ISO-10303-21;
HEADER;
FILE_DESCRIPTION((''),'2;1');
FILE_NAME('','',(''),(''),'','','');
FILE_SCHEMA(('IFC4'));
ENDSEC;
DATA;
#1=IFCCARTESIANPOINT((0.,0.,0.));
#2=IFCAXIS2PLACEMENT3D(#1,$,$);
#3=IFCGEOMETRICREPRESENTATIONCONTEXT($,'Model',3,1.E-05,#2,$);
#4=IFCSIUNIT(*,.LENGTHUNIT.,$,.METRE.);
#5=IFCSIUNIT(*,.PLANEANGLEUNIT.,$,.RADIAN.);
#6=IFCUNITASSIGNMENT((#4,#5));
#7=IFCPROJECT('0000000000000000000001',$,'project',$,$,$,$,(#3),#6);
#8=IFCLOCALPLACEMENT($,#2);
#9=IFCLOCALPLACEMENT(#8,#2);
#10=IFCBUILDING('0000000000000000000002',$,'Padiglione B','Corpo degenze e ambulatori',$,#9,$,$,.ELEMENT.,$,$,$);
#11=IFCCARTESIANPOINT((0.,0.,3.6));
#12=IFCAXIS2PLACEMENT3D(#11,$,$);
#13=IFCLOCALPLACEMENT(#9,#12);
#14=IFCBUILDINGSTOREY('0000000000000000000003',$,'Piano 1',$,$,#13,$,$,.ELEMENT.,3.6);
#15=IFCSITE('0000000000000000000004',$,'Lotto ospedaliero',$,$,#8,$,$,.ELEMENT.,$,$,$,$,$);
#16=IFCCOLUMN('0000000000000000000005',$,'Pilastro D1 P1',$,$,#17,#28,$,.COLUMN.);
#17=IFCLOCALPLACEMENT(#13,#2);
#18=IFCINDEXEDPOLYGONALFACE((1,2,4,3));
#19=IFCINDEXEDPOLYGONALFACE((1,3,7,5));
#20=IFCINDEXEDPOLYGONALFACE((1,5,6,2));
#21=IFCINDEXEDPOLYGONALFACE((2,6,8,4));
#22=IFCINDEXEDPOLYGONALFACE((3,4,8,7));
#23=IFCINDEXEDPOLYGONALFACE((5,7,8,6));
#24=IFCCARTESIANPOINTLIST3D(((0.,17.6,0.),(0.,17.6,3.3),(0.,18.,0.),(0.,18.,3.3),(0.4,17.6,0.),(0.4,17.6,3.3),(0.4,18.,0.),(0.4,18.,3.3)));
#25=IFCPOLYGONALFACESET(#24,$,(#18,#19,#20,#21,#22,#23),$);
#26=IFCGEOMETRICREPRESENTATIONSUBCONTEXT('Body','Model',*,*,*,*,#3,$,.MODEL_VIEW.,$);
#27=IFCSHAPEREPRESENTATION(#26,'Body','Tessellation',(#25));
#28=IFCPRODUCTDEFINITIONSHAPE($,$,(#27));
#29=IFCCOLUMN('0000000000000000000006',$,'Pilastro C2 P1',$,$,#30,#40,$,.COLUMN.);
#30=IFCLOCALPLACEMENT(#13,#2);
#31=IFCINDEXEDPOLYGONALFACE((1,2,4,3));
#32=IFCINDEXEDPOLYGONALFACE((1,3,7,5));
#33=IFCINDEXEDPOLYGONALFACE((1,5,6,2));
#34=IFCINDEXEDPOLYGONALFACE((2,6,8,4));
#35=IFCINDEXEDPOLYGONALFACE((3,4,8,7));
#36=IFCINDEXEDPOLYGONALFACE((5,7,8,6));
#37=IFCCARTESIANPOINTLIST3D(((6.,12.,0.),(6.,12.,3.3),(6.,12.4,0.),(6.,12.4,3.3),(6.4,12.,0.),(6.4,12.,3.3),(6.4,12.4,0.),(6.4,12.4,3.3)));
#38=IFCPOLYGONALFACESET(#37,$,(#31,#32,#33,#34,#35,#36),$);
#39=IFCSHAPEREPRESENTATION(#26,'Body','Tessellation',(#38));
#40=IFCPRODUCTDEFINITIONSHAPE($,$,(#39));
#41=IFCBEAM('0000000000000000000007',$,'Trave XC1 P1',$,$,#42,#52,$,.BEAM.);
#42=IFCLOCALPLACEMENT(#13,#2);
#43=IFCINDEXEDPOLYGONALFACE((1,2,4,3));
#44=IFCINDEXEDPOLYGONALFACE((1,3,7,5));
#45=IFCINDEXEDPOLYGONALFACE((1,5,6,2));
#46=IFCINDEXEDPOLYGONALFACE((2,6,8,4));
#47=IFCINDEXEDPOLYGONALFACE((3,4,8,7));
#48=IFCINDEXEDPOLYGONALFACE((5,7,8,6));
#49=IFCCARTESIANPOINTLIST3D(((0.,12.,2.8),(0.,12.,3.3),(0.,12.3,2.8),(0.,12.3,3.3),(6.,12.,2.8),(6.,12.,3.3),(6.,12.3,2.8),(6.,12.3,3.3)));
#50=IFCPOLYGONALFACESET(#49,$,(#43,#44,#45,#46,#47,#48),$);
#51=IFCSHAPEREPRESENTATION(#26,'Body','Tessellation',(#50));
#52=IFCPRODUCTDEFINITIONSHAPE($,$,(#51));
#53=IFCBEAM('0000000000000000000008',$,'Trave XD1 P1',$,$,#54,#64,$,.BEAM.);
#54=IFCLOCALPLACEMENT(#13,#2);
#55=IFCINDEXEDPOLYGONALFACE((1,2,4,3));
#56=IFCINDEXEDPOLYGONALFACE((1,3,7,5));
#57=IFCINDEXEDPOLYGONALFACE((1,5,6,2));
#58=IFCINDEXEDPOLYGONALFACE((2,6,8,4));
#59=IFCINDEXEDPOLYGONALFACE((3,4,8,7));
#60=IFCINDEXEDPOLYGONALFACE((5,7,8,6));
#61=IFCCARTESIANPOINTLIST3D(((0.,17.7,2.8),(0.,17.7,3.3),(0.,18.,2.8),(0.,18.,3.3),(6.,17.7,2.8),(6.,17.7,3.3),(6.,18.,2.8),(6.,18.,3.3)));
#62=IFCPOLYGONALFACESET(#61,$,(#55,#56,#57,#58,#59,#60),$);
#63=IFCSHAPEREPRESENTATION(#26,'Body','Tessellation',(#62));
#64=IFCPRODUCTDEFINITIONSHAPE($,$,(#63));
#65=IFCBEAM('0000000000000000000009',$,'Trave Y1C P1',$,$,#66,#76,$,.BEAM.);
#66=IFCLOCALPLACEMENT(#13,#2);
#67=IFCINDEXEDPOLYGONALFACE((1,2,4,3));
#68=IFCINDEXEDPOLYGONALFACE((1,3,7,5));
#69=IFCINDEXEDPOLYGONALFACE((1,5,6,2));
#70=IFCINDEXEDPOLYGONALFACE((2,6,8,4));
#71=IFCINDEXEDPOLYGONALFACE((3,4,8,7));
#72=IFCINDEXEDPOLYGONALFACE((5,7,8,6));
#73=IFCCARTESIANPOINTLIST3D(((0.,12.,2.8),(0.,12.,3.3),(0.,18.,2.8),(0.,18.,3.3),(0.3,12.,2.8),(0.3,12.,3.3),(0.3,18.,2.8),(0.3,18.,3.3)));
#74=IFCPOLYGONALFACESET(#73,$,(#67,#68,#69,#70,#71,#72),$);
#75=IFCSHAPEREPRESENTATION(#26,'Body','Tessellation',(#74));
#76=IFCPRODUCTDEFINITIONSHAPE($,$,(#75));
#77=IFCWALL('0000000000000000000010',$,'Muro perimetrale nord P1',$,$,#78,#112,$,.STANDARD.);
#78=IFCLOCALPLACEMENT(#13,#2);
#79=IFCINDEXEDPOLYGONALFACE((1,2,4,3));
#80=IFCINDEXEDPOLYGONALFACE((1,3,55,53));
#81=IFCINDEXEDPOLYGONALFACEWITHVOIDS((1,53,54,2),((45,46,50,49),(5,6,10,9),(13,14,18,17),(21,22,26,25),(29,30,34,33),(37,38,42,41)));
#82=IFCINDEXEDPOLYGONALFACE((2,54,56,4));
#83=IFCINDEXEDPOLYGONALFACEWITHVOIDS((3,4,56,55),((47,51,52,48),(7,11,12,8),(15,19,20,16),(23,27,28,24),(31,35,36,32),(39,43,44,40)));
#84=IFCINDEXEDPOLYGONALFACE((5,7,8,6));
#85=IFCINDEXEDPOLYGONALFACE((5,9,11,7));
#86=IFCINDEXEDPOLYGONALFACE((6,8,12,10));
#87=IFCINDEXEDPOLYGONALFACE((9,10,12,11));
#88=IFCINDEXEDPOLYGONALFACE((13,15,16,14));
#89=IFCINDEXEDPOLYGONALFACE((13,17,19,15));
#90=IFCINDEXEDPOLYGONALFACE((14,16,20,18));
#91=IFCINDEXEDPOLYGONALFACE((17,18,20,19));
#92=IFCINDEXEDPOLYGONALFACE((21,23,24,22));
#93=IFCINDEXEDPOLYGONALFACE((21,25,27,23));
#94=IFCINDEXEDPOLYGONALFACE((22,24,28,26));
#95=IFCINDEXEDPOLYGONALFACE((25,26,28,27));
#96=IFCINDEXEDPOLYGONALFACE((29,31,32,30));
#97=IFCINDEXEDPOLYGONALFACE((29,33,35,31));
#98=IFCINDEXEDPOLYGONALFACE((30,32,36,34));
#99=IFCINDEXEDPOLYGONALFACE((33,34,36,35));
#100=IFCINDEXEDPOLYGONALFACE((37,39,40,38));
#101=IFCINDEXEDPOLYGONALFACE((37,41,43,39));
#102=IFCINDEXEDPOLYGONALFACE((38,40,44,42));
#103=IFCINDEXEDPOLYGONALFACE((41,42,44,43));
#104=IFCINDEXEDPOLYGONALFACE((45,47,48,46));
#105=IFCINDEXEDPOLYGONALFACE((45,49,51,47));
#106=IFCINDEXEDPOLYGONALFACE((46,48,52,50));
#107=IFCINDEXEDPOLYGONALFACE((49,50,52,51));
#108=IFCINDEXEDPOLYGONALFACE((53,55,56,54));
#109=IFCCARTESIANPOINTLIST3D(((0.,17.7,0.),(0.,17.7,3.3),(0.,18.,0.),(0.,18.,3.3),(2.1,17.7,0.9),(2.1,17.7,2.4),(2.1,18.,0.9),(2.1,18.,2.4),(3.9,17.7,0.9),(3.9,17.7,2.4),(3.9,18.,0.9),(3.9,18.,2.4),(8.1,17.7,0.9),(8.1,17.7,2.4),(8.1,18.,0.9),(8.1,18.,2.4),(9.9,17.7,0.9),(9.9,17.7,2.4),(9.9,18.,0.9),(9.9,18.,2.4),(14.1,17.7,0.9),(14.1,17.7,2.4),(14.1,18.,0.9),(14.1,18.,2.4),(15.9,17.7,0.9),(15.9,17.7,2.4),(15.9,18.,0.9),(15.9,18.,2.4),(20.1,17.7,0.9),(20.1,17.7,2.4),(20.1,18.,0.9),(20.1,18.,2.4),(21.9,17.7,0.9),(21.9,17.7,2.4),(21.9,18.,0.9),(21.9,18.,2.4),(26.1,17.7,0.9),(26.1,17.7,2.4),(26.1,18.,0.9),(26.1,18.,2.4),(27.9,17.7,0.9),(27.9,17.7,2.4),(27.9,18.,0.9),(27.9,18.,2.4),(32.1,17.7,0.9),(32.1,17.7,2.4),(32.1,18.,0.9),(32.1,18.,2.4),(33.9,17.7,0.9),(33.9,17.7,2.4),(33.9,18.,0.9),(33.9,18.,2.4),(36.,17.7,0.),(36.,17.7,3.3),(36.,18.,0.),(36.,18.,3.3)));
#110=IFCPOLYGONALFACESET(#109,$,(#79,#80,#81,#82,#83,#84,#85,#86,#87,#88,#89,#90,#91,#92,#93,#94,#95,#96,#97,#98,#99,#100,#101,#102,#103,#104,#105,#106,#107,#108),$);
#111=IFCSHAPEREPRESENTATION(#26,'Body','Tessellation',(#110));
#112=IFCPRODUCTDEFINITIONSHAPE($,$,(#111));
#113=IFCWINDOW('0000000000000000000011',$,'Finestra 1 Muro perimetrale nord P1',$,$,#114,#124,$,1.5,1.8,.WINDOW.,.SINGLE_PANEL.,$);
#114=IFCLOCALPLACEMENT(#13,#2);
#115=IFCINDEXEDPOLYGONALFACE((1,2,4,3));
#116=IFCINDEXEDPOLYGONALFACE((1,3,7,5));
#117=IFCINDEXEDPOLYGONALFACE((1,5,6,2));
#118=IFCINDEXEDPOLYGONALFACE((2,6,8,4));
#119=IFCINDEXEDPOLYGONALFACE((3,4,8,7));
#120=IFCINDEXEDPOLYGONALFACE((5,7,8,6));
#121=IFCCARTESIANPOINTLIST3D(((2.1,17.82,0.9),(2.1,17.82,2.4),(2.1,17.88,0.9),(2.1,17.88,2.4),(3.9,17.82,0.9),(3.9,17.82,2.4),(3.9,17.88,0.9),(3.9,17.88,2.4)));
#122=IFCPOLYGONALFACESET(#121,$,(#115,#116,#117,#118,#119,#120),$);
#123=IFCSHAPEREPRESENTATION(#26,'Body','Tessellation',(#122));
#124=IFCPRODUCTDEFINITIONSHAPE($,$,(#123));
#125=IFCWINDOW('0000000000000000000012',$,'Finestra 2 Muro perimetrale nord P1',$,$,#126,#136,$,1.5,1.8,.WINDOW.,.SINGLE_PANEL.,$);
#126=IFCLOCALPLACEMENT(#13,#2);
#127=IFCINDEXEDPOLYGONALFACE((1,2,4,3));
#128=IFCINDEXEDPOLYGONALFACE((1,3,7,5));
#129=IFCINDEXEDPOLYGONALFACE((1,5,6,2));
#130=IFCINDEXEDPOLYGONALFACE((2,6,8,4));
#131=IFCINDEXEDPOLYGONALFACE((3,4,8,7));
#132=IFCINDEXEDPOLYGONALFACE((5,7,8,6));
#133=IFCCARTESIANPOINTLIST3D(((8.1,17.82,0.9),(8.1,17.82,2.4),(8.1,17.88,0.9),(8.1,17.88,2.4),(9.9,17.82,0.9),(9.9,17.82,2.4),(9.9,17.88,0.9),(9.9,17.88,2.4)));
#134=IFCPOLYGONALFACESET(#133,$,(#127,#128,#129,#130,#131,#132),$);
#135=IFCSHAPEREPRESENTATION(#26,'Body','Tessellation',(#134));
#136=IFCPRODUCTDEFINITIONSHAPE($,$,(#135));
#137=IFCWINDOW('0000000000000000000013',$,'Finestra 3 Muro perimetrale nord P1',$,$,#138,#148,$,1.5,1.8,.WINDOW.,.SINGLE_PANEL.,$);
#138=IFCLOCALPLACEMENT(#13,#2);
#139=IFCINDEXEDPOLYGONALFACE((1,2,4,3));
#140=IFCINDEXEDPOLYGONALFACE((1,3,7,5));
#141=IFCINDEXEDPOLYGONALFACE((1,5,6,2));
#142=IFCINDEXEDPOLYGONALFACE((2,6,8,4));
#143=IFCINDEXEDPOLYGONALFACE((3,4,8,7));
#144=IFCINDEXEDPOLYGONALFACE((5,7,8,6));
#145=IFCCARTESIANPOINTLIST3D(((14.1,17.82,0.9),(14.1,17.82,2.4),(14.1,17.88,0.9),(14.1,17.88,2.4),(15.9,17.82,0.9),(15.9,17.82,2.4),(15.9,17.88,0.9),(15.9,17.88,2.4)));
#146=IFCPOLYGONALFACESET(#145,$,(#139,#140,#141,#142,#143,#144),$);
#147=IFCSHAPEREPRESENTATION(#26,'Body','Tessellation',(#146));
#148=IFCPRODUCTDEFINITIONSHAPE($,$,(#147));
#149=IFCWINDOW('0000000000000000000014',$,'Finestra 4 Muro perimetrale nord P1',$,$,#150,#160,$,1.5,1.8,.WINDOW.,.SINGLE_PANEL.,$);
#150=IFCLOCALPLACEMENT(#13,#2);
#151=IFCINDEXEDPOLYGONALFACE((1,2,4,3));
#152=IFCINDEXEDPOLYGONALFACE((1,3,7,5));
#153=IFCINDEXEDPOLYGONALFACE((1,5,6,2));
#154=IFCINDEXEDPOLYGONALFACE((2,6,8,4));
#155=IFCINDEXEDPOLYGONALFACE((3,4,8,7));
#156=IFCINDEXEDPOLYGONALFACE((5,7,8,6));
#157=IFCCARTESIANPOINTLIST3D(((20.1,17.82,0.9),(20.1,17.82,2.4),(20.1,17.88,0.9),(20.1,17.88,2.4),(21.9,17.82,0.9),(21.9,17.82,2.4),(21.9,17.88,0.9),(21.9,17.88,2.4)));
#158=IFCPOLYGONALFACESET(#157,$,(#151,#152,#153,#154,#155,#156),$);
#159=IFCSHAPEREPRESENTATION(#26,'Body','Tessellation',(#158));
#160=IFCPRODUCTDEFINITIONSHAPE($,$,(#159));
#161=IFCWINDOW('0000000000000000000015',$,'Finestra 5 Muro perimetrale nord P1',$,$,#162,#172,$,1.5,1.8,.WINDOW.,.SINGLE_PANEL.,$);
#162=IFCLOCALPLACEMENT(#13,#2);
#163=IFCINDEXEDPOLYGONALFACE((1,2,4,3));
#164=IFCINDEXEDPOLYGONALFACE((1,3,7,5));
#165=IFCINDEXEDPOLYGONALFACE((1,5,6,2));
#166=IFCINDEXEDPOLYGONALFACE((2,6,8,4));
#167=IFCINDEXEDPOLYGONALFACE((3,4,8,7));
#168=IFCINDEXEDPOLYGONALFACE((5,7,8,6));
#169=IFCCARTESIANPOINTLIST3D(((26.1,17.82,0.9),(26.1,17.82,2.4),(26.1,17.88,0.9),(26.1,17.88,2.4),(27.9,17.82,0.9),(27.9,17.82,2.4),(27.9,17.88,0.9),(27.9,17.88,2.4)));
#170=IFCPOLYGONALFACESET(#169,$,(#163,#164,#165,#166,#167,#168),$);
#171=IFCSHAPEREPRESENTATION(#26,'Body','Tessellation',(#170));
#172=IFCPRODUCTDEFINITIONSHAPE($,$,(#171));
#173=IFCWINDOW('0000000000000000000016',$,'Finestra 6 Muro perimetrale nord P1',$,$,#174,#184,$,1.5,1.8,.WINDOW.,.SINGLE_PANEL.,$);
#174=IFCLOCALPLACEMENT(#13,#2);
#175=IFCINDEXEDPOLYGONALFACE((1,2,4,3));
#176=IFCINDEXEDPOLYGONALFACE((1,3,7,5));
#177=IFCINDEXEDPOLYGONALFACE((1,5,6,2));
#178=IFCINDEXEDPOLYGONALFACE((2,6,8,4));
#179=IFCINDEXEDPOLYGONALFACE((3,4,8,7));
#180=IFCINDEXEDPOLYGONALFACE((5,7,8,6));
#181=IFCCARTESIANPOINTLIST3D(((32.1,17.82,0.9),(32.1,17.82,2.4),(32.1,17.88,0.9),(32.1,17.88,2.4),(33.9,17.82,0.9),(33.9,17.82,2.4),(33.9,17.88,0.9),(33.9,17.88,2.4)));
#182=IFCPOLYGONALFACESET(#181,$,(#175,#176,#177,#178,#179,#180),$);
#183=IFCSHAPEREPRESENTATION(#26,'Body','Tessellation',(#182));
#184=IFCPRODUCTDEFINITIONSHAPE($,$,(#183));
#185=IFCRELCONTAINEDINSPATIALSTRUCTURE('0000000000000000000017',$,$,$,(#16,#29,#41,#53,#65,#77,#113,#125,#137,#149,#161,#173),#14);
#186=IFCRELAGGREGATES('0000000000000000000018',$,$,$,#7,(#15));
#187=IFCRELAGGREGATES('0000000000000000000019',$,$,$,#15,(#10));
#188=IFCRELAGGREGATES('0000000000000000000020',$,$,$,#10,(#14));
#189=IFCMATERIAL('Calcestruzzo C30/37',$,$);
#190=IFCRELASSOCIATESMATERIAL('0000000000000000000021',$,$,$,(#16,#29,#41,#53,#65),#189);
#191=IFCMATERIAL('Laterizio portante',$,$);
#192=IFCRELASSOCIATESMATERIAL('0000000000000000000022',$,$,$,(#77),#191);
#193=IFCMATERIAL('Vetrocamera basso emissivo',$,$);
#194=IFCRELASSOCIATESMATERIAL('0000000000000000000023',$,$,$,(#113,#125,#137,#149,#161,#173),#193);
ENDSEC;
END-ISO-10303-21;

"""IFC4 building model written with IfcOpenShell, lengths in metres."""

from ifc_helpers import new_model, si_unit, frame, frame_2d, origin, place, context, subcontext, project, spatial, rectangle, extrude, material, element, fill, save


model = new_model("IFC4")

# Units and contexts
model_context = context("Model", 3, precision=1e-05, world=origin())
body_context = subcontext(model_context, "Body", "Model", "MODEL_VIEW")
ifc_project = project(units=[si_unit("LENGTHUNIT", "METRE"), si_unit("PLANEANGLEUNIT", "RADIAN")], contexts=[model_context])

# Site, building, storey
site_placement = place(None, origin())
site = spatial("IfcSite", under=ifc_project, at=site_placement, Name="Lotto ospedaliero", CompositionType="ELEMENT")
building_placement = place(site_placement, origin())
building = spatial("IfcBuilding", under=site, at=building_placement, Name="Padiglione B", Description="Corpo degenze e ambulatori", CompositionType="ELEMENT")
storey_placement = place(building_placement, frame((0.0, 0.0, 3.6)))
storey = spatial("IfcBuildingStorey", under=building, at=storey_placement, Name="Piano 1", CompositionType="ELEMENT", Elevation=3.6)

# Columns
ifc_material_1 = material(Name="Calcestruzzo C30/37")
for number, where, name in (
    (1, (0.0, 17.6, 0.0), "Pilastro D1 P1"),
    (2, (6.0, 12.0, 0.0), "Pilastro C2 P1"),
):
    element("IfcColumn", number, at=place(storey_placement, frame(where)), inside=storey, material=ifc_material_1, Name=name, PredefinedType="COLUMN", context=body_context, shape_type="SweptSolid", body=[
        extrude(rectangle(XDim=0.4, YDim=0.4, at=frame_2d((0.2, 0.2))), origin(), (0.0, 0.0, 1.0), 3.3),
    ])

# Beams
for number, where, name in (
    (3, (0.0, 12.0, 2.8), "Trave XC1 P1"),
    (4, (0.0, 17.7, 2.8), "Trave XD1 P1"),
):
    element("IfcBeam", number, at=place(storey_placement, frame(where)), inside=storey, material=ifc_material_1, Name=name, PredefinedType="BEAM", context=body_context, shape_type="SweptSolid", body=[
        extrude(rectangle(XDim=6.0, YDim=0.3, at=frame_2d((3.0, 0.15))), origin(), (0.0, 0.0, 1.0), 0.5),
    ])
beam_placement = place(storey_placement, frame((0.0, 12.0, 2.8)))
element("IfcBeam", 5, at=beam_placement, inside=storey, material=ifc_material_1, Name="Trave Y1C P1", PredefinedType="BEAM", context=body_context, shape_type="SweptSolid", body=[
    extrude(rectangle(XDim=0.3, YDim=6.0, at=frame_2d((0.15, 3.0))), origin(), (0.0, 0.0, 1.0), 0.5),
])

# Wall, openings, windows
ifc_material_2 = material(Name="Laterizio portante")
wall_placement = place(storey_placement, frame((0.0, 17.7, 0.0)))
wall = element("IfcWall", 6, at=wall_placement, inside=storey, material=ifc_material_2, Name="Muro perimetrale nord P1", PredefinedType="STANDARD", context=body_context, shape_type="SweptSolid", body=[
    extrude(rectangle(XDim=36.0, YDim=0.3, at=frame_2d((18.0, 0.15))), origin(), (0.0, 0.0, 1.0), 3.3),
])
opening_1_placement = place(wall_placement, frame((2.1, -0.1, 0.9)))
opening_1 = element("IfcOpeningElement", 7, at=opening_1_placement, cuts=wall, PredefinedType="OPENING", context=body_context, shape_type="SweptSolid", body=[
    extrude(rectangle(XDim=1.8, YDim=0.5, at=frame_2d((0.9, 0.25))), origin(), (0.0, 0.0, 1.0), 1.5),
])
opening_2_placement = place(wall_placement, frame((8.1, -0.1, 0.9)))
opening_2 = element("IfcOpeningElement", 8, at=opening_2_placement, cuts=wall, PredefinedType="OPENING", context=body_context, shape_type="SweptSolid", body=[
    extrude(rectangle(XDim=1.8, YDim=0.5, at=frame_2d((0.9, 0.25))), origin(), (0.0, 0.0, 1.0), 1.5),
])
opening_3_placement = place(wall_placement, frame((14.1, -0.1, 0.9)))
opening_3 = element("IfcOpeningElement", 9, at=opening_3_placement, cuts=wall, PredefinedType="OPENING", context=body_context, shape_type="SweptSolid", body=[
    extrude(rectangle(XDim=1.8, YDim=0.5, at=frame_2d((0.9, 0.25))), origin(), (0.0, 0.0, 1.0), 1.5),
])
opening_4_placement = place(wall_placement, frame((20.1, -0.1, 0.9)))
opening_4 = element("IfcOpeningElement", 10, at=opening_4_placement, cuts=wall, PredefinedType="OPENING", context=body_context, shape_type="SweptSolid", body=[
    extrude(rectangle(XDim=1.8, YDim=0.5, at=frame_2d((0.9, 0.25))), origin(), (0.0, 0.0, 1.0), 1.5),
])
opening_5_placement = place(wall_placement, frame((26.1, -0.1, 0.9)))
opening_5 = element("IfcOpeningElement", 11, at=opening_5_placement, cuts=wall, PredefinedType="OPENING", context=body_context, shape_type="SweptSolid", body=[
    extrude(rectangle(XDim=1.8, YDim=0.5, at=frame_2d((0.9, 0.25))), origin(), (0.0, 0.0, 1.0), 1.5),
])
opening_6_placement = place(wall_placement, frame((32.1, -0.1, 0.9)))
opening_6 = element("IfcOpeningElement", 12, at=opening_6_placement, cuts=wall, PredefinedType="OPENING", context=body_context, shape_type="SweptSolid", body=[
    extrude(rectangle(XDim=1.8, YDim=0.5, at=frame_2d((0.9, 0.25))), origin(), (0.0, 0.0, 1.0), 1.5),
])
ifc_material_3 = material(Name="Vetrocamera basso emissivo")
window_1_placement = place(wall_placement, frame((2.1, 0.12, 0.9)))
window_1 = element("IfcWindow", 13, at=window_1_placement, inside=storey, material=ifc_material_3, Name="Finestra 1 Muro perimetrale nord P1", OverallHeight=1.5, OverallWidth=1.8, PartitioningType="SINGLE_PANEL", PredefinedType="WINDOW", context=body_context, shape_type="SweptSolid", body=[
    extrude(rectangle(XDim=1.8, YDim=0.06, at=frame_2d((0.9, 0.03))), origin(), (0.0, 0.0, 1.0), 1.5),
])
fill(opening_1, window_1)
window_2_placement = place(wall_placement, frame((8.1, 0.12, 0.9)))
window_2 = element("IfcWindow", 14, at=window_2_placement, inside=storey, material=ifc_material_3, Name="Finestra 2 Muro perimetrale nord P1", OverallHeight=1.5, OverallWidth=1.8, PartitioningType="SINGLE_PANEL", PredefinedType="WINDOW", context=body_context, shape_type="SweptSolid", body=[
    extrude(rectangle(XDim=1.8, YDim=0.06, at=frame_2d((0.9, 0.03))), origin(), (0.0, 0.0, 1.0), 1.5),
])
fill(opening_2, window_2)
window_3_placement = place(wall_placement, frame((14.1, 0.12, 0.9)))
window_3 = element("IfcWindow", 15, at=window_3_placement, inside=storey, material=ifc_material_3, Name="Finestra 3 Muro perimetrale nord P1", OverallHeight=1.5, OverallWidth=1.8, PartitioningType="SINGLE_PANEL", PredefinedType="WINDOW", context=body_context, shape_type="SweptSolid", body=[
    extrude(rectangle(XDim=1.8, YDim=0.06, at=frame_2d((0.9, 0.03))), origin(), (0.0, 0.0, 1.0), 1.5),
])
fill(opening_3, window_3)
window_4_placement = place(wall_placement, frame((20.1, 0.12, 0.9)))
window_4 = element("IfcWindow", 16, at=window_4_placement, inside=storey, material=ifc_material_3, Name="Finestra 4 Muro perimetrale nord P1", OverallHeight=1.5, OverallWidth=1.8, PartitioningType="SINGLE_PANEL", PredefinedType="WINDOW", context=body_context, shape_type="SweptSolid", body=[
    extrude(rectangle(XDim=1.8, YDim=0.06, at=frame_2d((0.9, 0.03))), origin(), (0.0, 0.0, 1.0), 1.5),
])
fill(opening_4, window_4)
window_5_placement = place(wall_placement, frame((26.1, 0.12, 0.9)))
window_5 = element("IfcWindow", 17, at=window_5_placement, inside=storey, material=ifc_material_3, Name="Finestra 5 Muro perimetrale nord P1", OverallHeight=1.5, OverallWidth=1.8, PartitioningType="SINGLE_PANEL", PredefinedType="WINDOW", context=body_context, shape_type="SweptSolid", body=[
    extrude(rectangle(XDim=1.8, YDim=0.06, at=frame_2d((0.9, 0.03))), origin(), (0.0, 0.0, 1.0), 1.5),
])
fill(opening_5, window_5)
window_6_placement = place(wall_placement, frame((32.1, 0.12, 0.9)))
window_6 = element("IfcWindow", 18, at=window_6_placement, inside=storey, material=ifc_material_3, Name="Finestra 6 Muro perimetrale nord P1", OverallHeight=1.5, OverallWidth=1.8, PartitioningType="SINGLE_PANEL", PredefinedType="WINDOW", context=body_context, shape_type="SweptSolid", body=[
    extrude(rectangle(XDim=1.8, YDim=0.06, at=frame_2d((0.9, 0.03))), origin(), (0.0, 0.0, 1.0), 1.5),
])
fill(opening_6, window_6)

save(model, "model.ifc")
